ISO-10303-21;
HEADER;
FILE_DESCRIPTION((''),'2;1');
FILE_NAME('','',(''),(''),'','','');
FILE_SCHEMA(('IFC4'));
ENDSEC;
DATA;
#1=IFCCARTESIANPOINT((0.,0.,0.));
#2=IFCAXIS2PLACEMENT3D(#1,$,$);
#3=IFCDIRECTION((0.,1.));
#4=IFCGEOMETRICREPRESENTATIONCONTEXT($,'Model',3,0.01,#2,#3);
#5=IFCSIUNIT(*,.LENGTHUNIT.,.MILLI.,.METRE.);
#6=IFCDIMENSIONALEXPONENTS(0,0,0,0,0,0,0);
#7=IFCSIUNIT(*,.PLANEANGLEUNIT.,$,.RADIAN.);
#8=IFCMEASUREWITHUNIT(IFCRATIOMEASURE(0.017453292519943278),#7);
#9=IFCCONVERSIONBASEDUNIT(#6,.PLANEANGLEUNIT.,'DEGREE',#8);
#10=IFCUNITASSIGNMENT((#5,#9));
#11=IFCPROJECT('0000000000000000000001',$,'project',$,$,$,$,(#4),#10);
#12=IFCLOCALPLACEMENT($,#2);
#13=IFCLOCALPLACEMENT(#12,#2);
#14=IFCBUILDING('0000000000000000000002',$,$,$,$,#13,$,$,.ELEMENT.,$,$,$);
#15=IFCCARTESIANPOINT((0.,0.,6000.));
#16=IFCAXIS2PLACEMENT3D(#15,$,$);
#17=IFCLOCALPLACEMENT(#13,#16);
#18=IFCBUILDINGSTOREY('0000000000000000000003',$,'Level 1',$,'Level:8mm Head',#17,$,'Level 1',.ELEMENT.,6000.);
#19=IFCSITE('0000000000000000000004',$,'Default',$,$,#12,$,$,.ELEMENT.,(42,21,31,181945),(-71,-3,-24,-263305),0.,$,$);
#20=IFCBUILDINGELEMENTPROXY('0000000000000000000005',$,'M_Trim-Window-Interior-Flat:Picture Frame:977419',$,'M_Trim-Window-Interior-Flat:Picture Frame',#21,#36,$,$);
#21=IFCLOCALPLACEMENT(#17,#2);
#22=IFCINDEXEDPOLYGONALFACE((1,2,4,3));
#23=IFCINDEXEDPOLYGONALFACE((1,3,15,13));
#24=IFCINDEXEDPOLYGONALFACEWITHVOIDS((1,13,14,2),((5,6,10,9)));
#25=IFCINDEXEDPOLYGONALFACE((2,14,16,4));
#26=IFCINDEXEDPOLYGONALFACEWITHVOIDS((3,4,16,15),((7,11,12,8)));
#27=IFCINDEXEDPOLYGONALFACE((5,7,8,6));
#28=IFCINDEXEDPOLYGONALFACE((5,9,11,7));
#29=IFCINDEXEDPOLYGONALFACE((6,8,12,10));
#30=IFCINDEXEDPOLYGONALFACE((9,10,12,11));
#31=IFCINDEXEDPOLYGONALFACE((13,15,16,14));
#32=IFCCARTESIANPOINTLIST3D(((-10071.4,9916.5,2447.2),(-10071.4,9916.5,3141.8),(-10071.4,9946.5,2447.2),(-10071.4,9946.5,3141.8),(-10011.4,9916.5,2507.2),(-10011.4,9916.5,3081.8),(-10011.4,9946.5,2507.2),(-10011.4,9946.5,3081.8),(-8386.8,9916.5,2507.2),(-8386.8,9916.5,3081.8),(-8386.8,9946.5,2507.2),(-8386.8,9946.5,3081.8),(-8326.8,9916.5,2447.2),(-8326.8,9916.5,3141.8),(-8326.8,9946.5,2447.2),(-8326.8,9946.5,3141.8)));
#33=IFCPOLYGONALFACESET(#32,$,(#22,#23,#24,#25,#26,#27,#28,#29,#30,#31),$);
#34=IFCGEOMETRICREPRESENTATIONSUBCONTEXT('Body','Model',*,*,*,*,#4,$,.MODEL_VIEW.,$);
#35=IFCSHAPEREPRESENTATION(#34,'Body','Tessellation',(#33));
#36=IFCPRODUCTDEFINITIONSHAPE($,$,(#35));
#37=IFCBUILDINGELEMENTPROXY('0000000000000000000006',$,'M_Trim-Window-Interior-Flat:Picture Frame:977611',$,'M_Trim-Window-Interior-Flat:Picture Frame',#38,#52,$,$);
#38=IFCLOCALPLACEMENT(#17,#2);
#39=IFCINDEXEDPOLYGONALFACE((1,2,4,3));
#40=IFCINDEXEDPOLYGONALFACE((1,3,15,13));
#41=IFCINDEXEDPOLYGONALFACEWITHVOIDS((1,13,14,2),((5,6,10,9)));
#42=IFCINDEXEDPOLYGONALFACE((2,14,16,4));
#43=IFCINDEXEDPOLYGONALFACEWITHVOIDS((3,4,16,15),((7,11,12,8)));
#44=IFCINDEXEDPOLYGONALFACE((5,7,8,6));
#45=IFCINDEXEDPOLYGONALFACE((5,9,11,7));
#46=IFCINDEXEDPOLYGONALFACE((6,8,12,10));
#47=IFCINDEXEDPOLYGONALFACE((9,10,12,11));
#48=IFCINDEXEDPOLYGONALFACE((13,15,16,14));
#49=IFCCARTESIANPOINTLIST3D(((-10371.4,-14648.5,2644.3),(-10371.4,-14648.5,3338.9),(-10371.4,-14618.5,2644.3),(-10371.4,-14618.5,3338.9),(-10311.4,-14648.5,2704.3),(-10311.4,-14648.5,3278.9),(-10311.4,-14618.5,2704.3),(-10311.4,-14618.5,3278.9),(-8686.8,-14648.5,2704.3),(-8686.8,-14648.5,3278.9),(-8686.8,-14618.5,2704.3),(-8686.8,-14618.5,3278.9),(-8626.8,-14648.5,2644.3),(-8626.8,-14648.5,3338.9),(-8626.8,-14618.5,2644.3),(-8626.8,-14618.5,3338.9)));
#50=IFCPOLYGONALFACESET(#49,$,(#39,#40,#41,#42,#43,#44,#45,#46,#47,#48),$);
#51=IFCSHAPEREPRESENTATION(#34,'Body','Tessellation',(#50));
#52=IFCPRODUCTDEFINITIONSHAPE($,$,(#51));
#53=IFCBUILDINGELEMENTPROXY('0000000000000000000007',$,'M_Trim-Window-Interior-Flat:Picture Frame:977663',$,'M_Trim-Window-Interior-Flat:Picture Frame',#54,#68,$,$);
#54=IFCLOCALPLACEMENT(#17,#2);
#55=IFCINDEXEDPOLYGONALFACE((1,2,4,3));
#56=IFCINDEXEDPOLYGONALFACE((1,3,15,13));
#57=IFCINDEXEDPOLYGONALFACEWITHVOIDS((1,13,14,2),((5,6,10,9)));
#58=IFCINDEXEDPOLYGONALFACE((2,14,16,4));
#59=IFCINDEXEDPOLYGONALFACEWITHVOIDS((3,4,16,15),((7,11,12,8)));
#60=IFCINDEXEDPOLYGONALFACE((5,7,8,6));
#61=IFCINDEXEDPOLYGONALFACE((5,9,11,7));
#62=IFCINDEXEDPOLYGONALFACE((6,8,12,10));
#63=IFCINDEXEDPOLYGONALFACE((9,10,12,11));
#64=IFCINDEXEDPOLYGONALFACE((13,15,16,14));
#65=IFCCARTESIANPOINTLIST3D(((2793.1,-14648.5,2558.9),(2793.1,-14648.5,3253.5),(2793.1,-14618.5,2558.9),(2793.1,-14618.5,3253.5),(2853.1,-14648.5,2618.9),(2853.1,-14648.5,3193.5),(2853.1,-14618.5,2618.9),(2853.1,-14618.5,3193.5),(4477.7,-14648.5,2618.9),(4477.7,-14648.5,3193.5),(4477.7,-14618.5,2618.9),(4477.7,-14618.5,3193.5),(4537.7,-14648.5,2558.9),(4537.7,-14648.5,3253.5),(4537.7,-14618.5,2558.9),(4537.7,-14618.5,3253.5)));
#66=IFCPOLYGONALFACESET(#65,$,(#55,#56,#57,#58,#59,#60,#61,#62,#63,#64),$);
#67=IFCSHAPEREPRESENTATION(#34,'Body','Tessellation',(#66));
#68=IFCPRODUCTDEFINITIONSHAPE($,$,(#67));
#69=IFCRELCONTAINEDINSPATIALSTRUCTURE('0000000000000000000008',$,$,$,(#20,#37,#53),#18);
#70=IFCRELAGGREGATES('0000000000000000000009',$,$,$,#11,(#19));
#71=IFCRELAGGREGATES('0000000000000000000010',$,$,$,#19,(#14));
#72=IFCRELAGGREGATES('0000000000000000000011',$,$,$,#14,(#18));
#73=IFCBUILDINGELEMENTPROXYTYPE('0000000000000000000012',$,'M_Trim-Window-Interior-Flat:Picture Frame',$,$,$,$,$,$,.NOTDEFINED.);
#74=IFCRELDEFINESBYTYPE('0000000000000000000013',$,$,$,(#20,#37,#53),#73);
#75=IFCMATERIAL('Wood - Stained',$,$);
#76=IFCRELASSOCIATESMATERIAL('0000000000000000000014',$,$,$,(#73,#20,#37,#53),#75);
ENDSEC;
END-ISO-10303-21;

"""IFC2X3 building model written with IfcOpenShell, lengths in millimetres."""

from ifc_helpers import new_model, entity, si_unit, converted_unit, direction, frame, origin, place, context, subcontext, project, spatial, polyline, outline, extrude, source, transform, mapped, material, type_object, type_shapes, element, save


model = new_model("IFC2X3")

# Units and contexts
model_context = context("Model", 3, precision=0.01, world=origin(), true_north=direction((0.0, 1.0)))
body_context = subcontext(model_context, "Body", "Model", "MODEL_VIEW")
ifc_project = project(units=[si_unit("LENGTHUNIT", "METRE", prefix="MILLI"), converted_unit("PLANEANGLEUNIT", "DEGREE", entity("IfcRatioMeasure", 0.017453292519943278), si_unit("PLANEANGLEUNIT", "RADIAN"), dimensions=[0, 0, 0, 0, 0, 0, 0])], contexts=[model_context])

# Site, building, storey
site_placement = place(None, origin())
site = spatial("IfcSite", under=ifc_project, at=site_placement, Name="Default", CompositionType="ELEMENT", RefLatitude=(42, 21, 31, 181945), RefLongitude=(-71, -3, -24, -263305), RefElevation=0.0)
building_placement = place(site_placement, origin())
building = spatial("IfcBuilding", under=site, at=building_placement, CompositionType="ELEMENT")
storey_placement = place(building_placement, frame((0.0, 0.0, 6000.0)))
storey = spatial("IfcBuildingStorey", under=building, at=storey_placement, Name="Level 1", ObjectType="Level:8mm Head", LongName="Level 1", CompositionType="ELEMENT", Elevation=6000.0)

# Building element proxies
ifc_material_1 = material(Name="Wood - Stained")
building_element_proxy_type_1 = type_object("IfcBuildingElementProxyType", Name="M_Trim-Window-Interior-Flat:Picture Frame", PredefinedType="NOTDEFINED", material=ifc_material_1)
shared_shape_1 = source(origin(), body_context, "Body", "SweptSolid", [
    extrude(outline(polyline([(-872.3, -347.3), (872.3, -347.3), (872.3, 347.3), (-872.3, 347.3), (-872.3, -347.3)]), holes=[polyline([(-812.3, -287.3), (-812.3, 287.3), (812.3, 287.3), (812.3, -287.3), (-812.3, -287.3)])]), frame((0.0, -300.0, 0.0), z_axis=(0.0, 0.0, 1.0), x_axis=(-1.0, 0.0, 0.0)), (0.0, 0.0, 1.0), 30.0),
])
type_shapes(building_element_proxy_type_1, [shared_shape_1])
for number, where, z_axis, x_axis, name in (
    (1, (-9199.1, 9946.5, 3094.5), (0.0, -1.0, 0.0), (1.0, 0.0, 0.0), "M_Trim-Window-Interior-Flat:Picture Frame:977419"),
    (2, (-9499.1, -14648.5, 3291.6), (0.0, 1.0, 0.0), (-1.0, 0.0, 0.0), "M_Trim-Window-Interior-Flat:Picture Frame:977611"),
    (3, (3665.4, -14648.5, 3206.2), (0.0, 1.0, 0.0), (-1.0, 0.0, 0.0), "M_Trim-Window-Interior-Flat:Picture Frame:977663"),
):
    element("IfcBuildingElementProxy", number, at=place(storey_placement, frame(where, z_axis=z_axis, x_axis=x_axis)), inside=storey, type_object=building_element_proxy_type_1, material=ifc_material_1, Name=name, ObjectType="M_Trim-Window-Interior-Flat:Picture Frame", context=body_context, shape_type="MappedRepresentation", body=[
        mapped(shared_shape_1, transform((0.0, 0.0, 0.0), scale=1.0)),
    ])

save(model, "model.ifc")
